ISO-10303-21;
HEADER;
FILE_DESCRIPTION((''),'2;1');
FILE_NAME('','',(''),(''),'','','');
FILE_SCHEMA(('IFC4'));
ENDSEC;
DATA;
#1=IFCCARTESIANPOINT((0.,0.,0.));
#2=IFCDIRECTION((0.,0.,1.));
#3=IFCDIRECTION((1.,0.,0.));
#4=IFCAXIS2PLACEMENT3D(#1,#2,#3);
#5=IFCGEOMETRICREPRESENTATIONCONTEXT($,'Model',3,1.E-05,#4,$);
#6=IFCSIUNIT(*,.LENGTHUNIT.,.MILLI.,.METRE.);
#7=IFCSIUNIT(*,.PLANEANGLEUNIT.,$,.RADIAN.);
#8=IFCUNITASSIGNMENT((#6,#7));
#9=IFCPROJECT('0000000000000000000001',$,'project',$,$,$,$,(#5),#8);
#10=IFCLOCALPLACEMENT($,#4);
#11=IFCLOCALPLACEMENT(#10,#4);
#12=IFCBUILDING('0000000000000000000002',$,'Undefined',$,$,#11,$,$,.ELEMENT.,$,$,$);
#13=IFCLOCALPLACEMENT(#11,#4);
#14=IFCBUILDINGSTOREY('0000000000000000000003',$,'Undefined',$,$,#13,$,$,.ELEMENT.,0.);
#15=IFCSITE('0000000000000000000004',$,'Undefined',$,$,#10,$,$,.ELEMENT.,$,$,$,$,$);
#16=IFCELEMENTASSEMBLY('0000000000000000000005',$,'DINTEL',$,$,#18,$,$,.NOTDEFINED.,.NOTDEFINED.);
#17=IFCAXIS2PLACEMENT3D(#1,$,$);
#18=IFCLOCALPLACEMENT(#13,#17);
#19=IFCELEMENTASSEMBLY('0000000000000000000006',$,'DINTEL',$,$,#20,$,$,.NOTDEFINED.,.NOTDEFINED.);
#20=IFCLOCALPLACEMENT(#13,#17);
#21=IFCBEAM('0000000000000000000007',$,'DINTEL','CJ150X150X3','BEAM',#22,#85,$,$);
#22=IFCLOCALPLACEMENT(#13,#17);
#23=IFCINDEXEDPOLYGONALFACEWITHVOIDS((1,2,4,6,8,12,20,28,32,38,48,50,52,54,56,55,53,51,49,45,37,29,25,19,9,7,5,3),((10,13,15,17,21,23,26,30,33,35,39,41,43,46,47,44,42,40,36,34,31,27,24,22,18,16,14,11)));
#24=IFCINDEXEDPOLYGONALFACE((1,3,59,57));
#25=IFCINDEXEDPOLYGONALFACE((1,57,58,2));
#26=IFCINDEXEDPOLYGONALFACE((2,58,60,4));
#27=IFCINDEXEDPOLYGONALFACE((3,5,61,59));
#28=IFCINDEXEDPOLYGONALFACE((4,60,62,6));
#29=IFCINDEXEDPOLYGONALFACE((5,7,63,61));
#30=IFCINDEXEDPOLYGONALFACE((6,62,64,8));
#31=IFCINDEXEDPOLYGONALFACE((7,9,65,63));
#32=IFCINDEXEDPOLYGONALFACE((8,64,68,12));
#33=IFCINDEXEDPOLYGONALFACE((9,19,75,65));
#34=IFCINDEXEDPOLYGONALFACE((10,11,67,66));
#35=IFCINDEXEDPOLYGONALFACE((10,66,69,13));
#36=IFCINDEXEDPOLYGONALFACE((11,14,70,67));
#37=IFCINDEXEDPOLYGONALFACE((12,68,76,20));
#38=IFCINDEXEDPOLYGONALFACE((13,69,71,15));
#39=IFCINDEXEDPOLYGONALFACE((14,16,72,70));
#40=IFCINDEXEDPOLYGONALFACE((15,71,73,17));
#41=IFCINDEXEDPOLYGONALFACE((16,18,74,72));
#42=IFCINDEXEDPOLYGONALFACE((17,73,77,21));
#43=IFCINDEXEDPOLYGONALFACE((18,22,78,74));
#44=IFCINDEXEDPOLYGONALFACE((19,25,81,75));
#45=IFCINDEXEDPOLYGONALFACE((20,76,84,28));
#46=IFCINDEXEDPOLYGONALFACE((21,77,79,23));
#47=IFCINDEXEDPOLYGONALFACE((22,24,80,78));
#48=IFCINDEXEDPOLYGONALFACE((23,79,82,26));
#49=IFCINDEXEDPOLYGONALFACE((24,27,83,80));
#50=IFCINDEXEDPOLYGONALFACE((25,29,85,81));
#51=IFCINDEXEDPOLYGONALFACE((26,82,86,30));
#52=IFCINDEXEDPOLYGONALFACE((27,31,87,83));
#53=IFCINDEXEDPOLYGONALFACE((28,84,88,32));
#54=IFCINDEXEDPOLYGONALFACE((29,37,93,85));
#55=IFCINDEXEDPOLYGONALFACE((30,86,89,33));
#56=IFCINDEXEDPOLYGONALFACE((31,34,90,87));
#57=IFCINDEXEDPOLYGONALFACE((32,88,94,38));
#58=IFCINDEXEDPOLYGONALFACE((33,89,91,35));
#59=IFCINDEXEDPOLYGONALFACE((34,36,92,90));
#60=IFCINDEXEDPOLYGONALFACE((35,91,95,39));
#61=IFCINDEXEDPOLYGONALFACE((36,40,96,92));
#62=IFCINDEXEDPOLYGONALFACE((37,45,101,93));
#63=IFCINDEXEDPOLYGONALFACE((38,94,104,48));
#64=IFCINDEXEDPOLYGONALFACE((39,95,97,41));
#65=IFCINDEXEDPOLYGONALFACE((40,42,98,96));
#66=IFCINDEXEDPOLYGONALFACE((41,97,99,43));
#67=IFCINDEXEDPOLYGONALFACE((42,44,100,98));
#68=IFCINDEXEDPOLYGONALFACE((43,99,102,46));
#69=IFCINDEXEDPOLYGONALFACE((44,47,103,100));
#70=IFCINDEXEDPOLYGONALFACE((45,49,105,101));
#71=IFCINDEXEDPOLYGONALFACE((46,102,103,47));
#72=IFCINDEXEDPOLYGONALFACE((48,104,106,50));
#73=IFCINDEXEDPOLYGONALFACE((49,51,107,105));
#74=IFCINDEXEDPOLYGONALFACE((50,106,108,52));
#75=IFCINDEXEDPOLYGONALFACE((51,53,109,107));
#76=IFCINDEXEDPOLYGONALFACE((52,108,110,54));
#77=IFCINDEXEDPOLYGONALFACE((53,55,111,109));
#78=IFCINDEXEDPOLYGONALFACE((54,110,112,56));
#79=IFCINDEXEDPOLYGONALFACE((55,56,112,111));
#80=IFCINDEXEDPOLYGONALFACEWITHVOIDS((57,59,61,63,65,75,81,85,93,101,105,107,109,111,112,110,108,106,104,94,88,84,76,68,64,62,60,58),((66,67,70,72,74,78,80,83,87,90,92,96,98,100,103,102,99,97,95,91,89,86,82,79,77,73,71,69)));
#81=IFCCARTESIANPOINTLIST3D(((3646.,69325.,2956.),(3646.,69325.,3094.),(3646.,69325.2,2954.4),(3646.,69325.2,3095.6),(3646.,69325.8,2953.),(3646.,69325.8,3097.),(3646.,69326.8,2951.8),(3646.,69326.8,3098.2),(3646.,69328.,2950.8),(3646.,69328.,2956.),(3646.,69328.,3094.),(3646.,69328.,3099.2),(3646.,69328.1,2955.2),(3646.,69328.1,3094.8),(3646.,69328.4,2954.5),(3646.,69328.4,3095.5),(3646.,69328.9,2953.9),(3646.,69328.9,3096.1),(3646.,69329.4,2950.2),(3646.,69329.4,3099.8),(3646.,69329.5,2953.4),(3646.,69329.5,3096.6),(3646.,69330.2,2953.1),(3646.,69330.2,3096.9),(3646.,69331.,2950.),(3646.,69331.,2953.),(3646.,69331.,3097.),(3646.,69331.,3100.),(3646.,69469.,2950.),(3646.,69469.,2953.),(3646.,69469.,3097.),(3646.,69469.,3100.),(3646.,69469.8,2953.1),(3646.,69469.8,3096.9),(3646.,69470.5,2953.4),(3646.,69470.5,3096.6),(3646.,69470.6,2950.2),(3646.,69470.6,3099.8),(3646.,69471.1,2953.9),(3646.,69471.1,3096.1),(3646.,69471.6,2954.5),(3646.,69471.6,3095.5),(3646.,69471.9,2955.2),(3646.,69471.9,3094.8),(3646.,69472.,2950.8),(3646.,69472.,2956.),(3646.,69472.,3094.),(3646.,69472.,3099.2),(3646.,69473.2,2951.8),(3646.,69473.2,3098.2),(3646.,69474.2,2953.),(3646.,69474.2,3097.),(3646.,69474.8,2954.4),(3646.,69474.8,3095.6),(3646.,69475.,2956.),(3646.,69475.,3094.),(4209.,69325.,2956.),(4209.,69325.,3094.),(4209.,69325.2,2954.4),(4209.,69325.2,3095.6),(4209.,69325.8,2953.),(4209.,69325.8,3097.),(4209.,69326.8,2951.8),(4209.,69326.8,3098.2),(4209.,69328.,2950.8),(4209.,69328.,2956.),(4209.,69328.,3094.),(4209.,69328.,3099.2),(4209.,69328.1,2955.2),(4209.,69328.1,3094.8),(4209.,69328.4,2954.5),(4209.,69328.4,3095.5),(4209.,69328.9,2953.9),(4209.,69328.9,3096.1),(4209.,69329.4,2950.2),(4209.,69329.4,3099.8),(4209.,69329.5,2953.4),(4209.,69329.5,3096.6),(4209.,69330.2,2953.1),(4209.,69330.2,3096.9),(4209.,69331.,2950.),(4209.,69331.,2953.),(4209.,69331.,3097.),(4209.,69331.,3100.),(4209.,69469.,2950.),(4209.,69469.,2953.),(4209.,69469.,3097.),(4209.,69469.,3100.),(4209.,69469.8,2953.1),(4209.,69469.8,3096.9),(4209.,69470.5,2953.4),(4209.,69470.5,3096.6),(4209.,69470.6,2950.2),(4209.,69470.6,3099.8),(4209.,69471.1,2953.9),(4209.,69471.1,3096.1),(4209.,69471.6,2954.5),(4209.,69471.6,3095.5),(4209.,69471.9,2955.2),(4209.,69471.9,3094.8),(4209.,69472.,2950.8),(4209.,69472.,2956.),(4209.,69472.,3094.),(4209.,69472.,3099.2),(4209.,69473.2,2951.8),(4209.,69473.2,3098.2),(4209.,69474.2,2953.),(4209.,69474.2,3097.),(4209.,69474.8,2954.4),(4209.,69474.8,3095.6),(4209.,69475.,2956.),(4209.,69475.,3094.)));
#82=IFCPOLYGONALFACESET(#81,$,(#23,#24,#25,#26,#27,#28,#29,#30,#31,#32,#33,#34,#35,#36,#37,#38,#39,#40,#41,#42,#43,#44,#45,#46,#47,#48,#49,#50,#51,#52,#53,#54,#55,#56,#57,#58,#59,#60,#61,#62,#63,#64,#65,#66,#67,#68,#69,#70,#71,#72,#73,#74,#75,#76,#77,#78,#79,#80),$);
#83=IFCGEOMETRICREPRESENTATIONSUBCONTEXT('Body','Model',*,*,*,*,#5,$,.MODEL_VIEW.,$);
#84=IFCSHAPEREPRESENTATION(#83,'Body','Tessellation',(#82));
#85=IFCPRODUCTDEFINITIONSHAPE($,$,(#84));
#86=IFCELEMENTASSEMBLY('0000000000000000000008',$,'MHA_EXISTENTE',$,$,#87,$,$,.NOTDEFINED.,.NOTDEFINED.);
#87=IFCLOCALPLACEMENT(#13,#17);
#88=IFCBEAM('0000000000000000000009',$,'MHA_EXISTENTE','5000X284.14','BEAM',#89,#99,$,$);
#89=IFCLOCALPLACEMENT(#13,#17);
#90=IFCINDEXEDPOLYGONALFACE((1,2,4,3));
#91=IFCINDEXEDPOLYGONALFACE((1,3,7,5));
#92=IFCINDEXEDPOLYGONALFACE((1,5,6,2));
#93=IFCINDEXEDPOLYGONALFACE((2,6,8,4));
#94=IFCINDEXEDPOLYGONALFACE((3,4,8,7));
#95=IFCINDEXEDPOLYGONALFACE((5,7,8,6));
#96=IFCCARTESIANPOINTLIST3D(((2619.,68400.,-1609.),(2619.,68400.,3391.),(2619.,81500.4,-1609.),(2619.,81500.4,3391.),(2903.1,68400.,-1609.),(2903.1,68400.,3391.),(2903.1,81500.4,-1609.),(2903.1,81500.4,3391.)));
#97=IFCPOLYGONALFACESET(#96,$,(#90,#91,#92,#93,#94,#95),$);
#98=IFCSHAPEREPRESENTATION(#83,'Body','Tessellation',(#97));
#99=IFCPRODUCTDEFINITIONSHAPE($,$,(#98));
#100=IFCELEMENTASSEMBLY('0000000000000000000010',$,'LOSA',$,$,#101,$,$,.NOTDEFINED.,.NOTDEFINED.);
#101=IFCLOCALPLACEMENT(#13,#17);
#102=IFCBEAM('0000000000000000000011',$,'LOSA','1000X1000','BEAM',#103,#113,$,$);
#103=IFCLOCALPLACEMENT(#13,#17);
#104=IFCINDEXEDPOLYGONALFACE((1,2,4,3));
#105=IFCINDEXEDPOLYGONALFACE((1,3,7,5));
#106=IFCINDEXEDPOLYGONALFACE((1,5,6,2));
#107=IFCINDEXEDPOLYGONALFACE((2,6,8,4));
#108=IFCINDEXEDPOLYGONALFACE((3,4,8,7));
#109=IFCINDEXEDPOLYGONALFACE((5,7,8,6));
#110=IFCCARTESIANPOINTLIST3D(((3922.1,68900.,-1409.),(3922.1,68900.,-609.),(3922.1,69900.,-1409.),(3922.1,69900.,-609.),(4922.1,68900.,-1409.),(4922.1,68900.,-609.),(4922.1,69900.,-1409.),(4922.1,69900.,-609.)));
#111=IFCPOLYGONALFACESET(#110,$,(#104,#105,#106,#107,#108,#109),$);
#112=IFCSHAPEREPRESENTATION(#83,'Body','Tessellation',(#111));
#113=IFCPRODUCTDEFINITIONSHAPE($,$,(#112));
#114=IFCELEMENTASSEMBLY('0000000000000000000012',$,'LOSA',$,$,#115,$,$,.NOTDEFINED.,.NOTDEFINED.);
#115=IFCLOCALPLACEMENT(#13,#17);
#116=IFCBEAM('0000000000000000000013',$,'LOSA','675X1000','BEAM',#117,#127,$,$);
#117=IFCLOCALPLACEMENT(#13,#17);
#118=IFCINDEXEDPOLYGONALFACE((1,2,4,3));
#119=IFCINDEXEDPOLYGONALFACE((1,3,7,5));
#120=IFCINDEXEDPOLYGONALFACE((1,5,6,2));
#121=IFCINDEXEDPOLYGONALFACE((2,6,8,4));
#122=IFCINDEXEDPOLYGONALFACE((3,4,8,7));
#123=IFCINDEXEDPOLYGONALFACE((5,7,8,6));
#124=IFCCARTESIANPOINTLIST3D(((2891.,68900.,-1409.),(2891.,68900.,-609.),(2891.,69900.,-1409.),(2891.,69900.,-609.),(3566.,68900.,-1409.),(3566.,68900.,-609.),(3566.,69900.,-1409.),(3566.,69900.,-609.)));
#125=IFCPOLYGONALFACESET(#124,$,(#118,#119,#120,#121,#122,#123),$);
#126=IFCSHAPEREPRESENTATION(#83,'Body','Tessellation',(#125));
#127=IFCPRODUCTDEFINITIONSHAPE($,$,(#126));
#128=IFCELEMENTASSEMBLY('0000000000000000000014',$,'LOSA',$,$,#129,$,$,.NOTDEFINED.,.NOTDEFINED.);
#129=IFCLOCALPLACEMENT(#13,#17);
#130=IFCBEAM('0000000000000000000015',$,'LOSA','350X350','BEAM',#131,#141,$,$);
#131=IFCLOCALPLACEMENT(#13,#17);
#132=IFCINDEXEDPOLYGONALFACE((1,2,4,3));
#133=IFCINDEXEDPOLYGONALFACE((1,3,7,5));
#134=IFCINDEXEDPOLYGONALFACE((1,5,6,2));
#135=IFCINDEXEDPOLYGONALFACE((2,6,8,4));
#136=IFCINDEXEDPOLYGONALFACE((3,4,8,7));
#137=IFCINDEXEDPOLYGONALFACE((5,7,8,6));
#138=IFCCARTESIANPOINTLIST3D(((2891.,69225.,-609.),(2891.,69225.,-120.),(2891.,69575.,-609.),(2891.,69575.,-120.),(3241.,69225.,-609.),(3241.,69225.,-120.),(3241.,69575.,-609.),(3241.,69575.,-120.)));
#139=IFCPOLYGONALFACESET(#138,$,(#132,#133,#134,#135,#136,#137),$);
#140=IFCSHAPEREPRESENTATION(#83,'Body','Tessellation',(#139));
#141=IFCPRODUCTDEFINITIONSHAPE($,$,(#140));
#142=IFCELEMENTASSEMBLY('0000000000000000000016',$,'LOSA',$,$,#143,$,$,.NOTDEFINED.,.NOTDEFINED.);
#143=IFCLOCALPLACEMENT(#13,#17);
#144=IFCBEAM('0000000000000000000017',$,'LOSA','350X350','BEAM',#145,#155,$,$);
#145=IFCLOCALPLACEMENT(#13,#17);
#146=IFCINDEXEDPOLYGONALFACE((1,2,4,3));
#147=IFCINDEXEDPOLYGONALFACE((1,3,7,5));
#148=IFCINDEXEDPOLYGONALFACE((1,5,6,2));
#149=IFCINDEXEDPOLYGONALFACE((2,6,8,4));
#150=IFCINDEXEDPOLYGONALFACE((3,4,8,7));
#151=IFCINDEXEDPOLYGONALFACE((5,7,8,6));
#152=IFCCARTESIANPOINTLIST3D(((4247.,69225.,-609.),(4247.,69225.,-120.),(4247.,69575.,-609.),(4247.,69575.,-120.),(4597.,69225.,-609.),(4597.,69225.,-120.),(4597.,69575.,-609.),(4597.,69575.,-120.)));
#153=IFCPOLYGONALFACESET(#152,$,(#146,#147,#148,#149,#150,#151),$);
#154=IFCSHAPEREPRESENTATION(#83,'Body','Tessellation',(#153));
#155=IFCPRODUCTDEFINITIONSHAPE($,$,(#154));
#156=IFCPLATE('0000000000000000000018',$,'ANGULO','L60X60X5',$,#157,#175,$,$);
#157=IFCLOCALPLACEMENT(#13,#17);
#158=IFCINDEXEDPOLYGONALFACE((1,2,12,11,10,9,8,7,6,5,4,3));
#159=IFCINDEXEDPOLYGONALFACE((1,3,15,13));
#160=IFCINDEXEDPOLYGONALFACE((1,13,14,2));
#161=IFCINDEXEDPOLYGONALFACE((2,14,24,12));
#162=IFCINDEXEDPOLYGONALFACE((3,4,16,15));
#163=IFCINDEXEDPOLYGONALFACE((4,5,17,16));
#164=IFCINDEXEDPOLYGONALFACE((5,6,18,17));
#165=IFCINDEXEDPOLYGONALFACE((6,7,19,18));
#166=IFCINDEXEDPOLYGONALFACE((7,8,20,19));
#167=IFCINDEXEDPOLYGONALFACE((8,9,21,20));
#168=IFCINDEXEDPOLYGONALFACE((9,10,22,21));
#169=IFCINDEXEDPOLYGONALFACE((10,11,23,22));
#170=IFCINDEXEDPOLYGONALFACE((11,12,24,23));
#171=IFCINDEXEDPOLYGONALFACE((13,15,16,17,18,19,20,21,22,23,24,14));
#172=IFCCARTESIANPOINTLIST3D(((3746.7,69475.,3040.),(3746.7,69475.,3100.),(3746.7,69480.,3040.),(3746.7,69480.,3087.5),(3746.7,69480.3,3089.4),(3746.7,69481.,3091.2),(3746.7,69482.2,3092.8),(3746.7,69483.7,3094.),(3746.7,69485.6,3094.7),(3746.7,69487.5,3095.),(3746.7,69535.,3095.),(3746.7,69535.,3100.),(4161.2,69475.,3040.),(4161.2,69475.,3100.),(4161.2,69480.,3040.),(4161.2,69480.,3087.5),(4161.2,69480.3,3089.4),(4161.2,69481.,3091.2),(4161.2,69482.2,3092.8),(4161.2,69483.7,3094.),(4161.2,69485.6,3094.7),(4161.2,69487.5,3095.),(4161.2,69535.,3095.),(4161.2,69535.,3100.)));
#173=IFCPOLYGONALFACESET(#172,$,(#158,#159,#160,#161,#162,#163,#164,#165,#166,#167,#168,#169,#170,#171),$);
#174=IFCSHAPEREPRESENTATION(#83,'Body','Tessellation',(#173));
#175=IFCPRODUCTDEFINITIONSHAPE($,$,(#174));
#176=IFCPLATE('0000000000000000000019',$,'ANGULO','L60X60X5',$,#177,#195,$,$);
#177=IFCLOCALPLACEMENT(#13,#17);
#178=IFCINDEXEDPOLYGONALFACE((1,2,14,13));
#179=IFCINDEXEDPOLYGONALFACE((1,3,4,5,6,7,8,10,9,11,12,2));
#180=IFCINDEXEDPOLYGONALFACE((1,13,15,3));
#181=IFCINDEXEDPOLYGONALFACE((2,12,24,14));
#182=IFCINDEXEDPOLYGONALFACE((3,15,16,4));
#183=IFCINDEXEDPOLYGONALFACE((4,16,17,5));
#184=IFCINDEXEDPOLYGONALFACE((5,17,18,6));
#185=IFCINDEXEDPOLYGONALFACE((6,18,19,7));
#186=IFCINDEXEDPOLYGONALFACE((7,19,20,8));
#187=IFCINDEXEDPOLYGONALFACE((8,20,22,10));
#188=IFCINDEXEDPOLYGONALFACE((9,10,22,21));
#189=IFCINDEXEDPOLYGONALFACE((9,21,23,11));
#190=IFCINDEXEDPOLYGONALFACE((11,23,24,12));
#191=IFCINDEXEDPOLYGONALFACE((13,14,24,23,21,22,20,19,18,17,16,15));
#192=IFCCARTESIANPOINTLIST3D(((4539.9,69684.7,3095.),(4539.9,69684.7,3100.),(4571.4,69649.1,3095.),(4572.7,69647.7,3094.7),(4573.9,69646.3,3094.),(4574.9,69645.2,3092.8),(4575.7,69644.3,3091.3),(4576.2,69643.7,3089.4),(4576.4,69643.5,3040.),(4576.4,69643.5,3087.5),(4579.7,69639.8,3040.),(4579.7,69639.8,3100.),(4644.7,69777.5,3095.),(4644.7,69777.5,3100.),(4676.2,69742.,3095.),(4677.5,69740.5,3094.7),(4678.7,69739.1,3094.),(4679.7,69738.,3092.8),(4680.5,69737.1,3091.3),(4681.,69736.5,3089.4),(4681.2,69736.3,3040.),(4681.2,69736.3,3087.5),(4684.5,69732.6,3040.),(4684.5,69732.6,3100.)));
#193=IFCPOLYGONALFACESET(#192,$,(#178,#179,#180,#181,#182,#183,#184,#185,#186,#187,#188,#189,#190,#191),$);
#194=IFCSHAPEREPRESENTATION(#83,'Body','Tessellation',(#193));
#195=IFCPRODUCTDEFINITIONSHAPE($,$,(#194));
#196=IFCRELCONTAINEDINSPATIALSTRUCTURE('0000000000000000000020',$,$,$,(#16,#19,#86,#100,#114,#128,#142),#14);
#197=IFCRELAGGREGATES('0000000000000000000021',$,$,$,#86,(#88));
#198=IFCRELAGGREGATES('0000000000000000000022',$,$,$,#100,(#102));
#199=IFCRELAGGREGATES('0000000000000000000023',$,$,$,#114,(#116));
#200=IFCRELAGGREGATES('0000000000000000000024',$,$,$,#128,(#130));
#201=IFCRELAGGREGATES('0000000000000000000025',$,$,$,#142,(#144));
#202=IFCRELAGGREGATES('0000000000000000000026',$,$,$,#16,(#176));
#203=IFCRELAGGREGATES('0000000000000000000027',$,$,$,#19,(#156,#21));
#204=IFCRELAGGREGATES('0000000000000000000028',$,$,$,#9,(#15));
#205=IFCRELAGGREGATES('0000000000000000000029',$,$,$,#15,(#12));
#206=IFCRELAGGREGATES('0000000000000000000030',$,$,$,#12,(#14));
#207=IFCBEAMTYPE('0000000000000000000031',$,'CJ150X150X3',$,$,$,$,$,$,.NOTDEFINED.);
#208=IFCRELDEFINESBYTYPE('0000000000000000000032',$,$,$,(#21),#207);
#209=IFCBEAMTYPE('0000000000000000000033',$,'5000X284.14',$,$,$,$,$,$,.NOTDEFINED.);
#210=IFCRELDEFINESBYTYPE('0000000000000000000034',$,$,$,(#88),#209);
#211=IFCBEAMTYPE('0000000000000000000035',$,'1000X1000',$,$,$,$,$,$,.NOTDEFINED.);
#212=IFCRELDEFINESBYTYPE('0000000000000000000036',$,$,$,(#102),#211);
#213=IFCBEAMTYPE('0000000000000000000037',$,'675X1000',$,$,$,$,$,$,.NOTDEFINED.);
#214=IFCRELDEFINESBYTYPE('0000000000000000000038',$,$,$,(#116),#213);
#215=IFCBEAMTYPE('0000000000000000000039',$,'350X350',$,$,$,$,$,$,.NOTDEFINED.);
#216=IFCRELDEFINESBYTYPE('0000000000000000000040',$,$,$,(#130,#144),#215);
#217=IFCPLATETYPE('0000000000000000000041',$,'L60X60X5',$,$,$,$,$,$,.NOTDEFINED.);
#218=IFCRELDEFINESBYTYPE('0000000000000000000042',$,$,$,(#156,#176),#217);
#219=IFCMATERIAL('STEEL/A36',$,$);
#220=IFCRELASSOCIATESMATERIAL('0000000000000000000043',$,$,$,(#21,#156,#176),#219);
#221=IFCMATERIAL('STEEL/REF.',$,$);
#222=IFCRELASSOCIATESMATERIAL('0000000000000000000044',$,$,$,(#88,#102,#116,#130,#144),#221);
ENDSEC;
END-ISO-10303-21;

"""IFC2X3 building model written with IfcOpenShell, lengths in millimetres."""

from ifc_helpers import new_model, si_unit, frame, origin_with_axes, origin_2d_with_axis, place, context, subcontext, project, spatial, rectangle, hollow_rectangle, l_section, extrude, material, type_object, element, aggregate, save


model = new_model("IFC2X3")

# Units and contexts
model_context = context("Model", 3, precision=1e-05, world=origin_with_axes())
body_context = subcontext(model_context, "Body", "Model", "MODEL_VIEW")
ifc_project = project(units=[si_unit("LENGTHUNIT", "METRE", prefix="MILLI"), si_unit("PLANEANGLEUNIT", "RADIAN")], contexts=[model_context])

# Site, building, storey
site_placement = place(None, origin_with_axes())
site = spatial("IfcSite", under=ifc_project, at=site_placement, Name="Undefined", CompositionType="ELEMENT")
building_placement = place(site_placement, origin_with_axes())
building = spatial("IfcBuilding", under=site, at=building_placement, Name="Undefined", CompositionType="ELEMENT")
storey_placement = place(building_placement, origin_with_axes())
storey = spatial("IfcBuildingStorey", under=building, at=storey_placement, Name="Undefined", CompositionType="ELEMENT", Elevation=0.0)

# Element assemblies, beams
assembly_1_placement = place(storey_placement, origin_with_axes())
assembly_1 = element("IfcElementAssembly", 1, at=assembly_1_placement, inside=storey, Name="DINTEL", AssemblyPlace="NOTDEFINED", PredefinedType="NOTDEFINED")
ifc_material_1 = material(Name="STEEL/A36")
beam_type_1 = type_object("IfcBeamType", Name="CJ150X150X3", PredefinedType="NOTDEFINED")
assembly_2_placement = place(storey_placement, origin_with_axes())
assembly_2 = element("IfcElementAssembly", 2, at=assembly_2_placement, inside=storey, Name="DINTEL", AssemblyPlace="NOTDEFINED", PredefinedType="NOTDEFINED")
beam_1_placement = place(assembly_2_placement, frame((3646.0, 69400.0, 3025.0), z_axis=(0.0, 0.0, 1.0), x_axis=(1.0, 0.0, 0.0)))
beam_1 = element("IfcBeam", 3, at=beam_1_placement, type_object=beam_type_1, material=ifc_material_1, Name="DINTEL", Description="CJ150X150X3", ObjectType="BEAM", context=body_context, shape_type="SweptSolid", body=[
    extrude(hollow_rectangle(XDim=150.0, YDim=150.0, WallThickness=3.0, InnerFilletRadius=3.0, OuterFilletRadius=6.0, at=origin_2d_with_axis()), frame((563.0, 0.0, 0.0), z_axis=(-1.0, 0.0, 0.0), x_axis=(0.0, -1.0, 0.0)), (0.0, 0.0, 1.0), 563.0),
])
assembly_3_placement = place(storey_placement, origin_with_axes())
assembly_3 = element("IfcElementAssembly", 4, at=assembly_3_placement, inside=storey, Name="MHA_EXISTENTE", AssemblyPlace="NOTDEFINED", PredefinedType="NOTDEFINED")
ifc_material_2 = material(Name="STEEL/REF.")
beam_type_2 = type_object("IfcBeamType", Name="5000X284.14", PredefinedType="NOTDEFINED")
beam_2_placement = place(assembly_3_placement, frame((2761.1, 68400.0, 891.0), z_axis=(0.0, 0.0, 1.0), x_axis=(0.0, 1.0, 0.0)))
beam_2 = element("IfcBeam", 5, at=beam_2_placement, type_object=beam_type_2, material=ifc_material_2, Name="MHA_EXISTENTE", Description="5000X284.14", ObjectType="BEAM", context=body_context, shape_type="SweptSolid", body=[
    extrude(rectangle(XDim=284.1, YDim=5000.0, at=origin_2d_with_axis()), frame((13100.4, 0.0, 0.0), z_axis=(-1.0, 0.0, 0.0), x_axis=(0.0, -1.0, 0.0)), (0.0, 0.0, 1.0), 13100.4),
])
aggregate(assembly_3, [beam_2])
assembly_4_placement = place(storey_placement, origin_with_axes())
assembly_4 = element("IfcElementAssembly", 6, at=assembly_4_placement, inside=storey, Name="LOSA", AssemblyPlace="NOTDEFINED", PredefinedType="NOTDEFINED")
beam_type_3 = type_object("IfcBeamType", Name="1000X1000", PredefinedType="NOTDEFINED")
beam_3_placement = place(assembly_4_placement, frame((4422.1, 69400.0, -609.0), z_axis=(1.0, 0.0, 0.0), x_axis=(0.0, 0.0, -1.0)))
beam_3 = element("IfcBeam", 7, at=beam_3_placement, type_object=beam_type_3, material=ifc_material_2, Name="LOSA", Description="1000X1000", ObjectType="BEAM", context=body_context, shape_type="SweptSolid", body=[
    extrude(rectangle(XDim=1000.0, YDim=1000.0, at=origin_2d_with_axis()), frame((800.0, 0.0, 0.0), z_axis=(-1.0, 0.0, 0.0), x_axis=(0.0, -1.0, 0.0)), (0.0, 0.0, 1.0), 800.0),
])
aggregate(assembly_4, [beam_3])
assembly_5_placement = place(storey_placement, origin_with_axes())
assembly_5 = element("IfcElementAssembly", 8, at=assembly_5_placement, inside=storey, Name="LOSA", AssemblyPlace="NOTDEFINED", PredefinedType="NOTDEFINED")
beam_type_4 = type_object("IfcBeamType", Name="675X1000", PredefinedType="NOTDEFINED")
beam_4_placement = place(assembly_5_placement, frame((3228.5, 69400.0, -609.0), z_axis=(1.0, 0.0, 0.0), x_axis=(0.0, 0.0, -1.0)))
beam_4 = element("IfcBeam", 9, at=beam_4_placement, type_object=beam_type_4, material=ifc_material_2, Name="LOSA", Description="675X1000", ObjectType="BEAM", context=body_context, shape_type="SweptSolid", body=[
    extrude(rectangle(XDim=1000.0, YDim=675.0, at=origin_2d_with_axis()), frame((800.0, 0.0, 0.0), z_axis=(-1.0, 0.0, 0.0), x_axis=(0.0, -1.0, 0.0)), (0.0, 0.0, 1.0), 800.0),
])
aggregate(assembly_5, [beam_4])
assembly_6_placement = place(storey_placement, origin_with_axes())
assembly_6 = element("IfcElementAssembly", 10, at=assembly_6_placement, inside=storey, Name="LOSA", AssemblyPlace="NOTDEFINED", PredefinedType="NOTDEFINED")
beam_type_5 = type_object("IfcBeamType", Name="350X350", PredefinedType="NOTDEFINED")
beam_5_placement = place(assembly_6_placement, frame((3066.0, 69400.0, -120.0), z_axis=(1.0, 0.0, 0.0), x_axis=(0.0, 0.0, -1.0)))
beam_5 = element("IfcBeam", 11, at=beam_5_placement, type_object=beam_type_5, material=ifc_material_2, Name="LOSA", Description="350X350", ObjectType="BEAM", context=body_context, shape_type="SweptSolid", body=[
    extrude(rectangle(XDim=350.0, YDim=350.0, at=origin_2d_with_axis()), frame((489.0, 0.0, 0.0), z_axis=(-1.0, 0.0, 0.0), x_axis=(0.0, -1.0, 0.0)), (0.0, 0.0, 1.0), 489.0),
])
aggregate(assembly_6, [beam_5])
assembly_7_placement = place(storey_placement, origin_with_axes())
assembly_7 = element("IfcElementAssembly", 12, at=assembly_7_placement, inside=storey, Name="LOSA", AssemblyPlace="NOTDEFINED", PredefinedType="NOTDEFINED")
beam_6_placement = place(assembly_7_placement, frame((4422.0, 69400.0, -120.0), z_axis=(1.0, 0.0, 0.0), x_axis=(0.0, 0.0, -1.0)))
beam_6 = element("IfcBeam", 13, at=beam_6_placement, type_object=beam_type_5, material=ifc_material_2, Name="LOSA", Description="350X350", ObjectType="BEAM", context=body_context, shape_type="SweptSolid", body=[
    extrude(rectangle(XDim=350.0, YDim=350.0, at=origin_2d_with_axis()), frame((489.0, 0.0, 0.0), z_axis=(-1.0, 0.0, 0.0), x_axis=(0.0, -1.0, 0.0)), (0.0, 0.0, 1.0), 489.0),
])
aggregate(assembly_7, [beam_6])

# Plates
plate_type_1 = type_object("IfcPlateType", Name="L60X60X5", PredefinedType="NOTDEFINED")
plate_1_placement = place(assembly_2_placement, frame((3746.7, 69505.0, 3070.0), z_axis=(0.0, 0.0, -1.0), x_axis=(1.0, 0.0, 0.0)))
plate_1 = element("IfcPlate", 14, at=plate_1_placement, type_object=plate_type_1, material=ifc_material_1, Name="ANGULO", Description="L60X60X5", context=body_context, shape_type="SweptSolid", body=[
    extrude(l_section(Depth=60.0, Width=60.0, Thickness=5.0, FilletRadius=7.5, at=origin_2d_with_axis()), frame((414.5, 0.0, 0.0), z_axis=(-1.0, 0.0, 0.0), x_axis=(0.0, -1.0, 0.0)), (0.0, 0.0, 1.0), 414.5),
])
plate_2_placement = place(assembly_1_placement, frame((4559.8, 69662.3, 3070.0), z_axis=(0.0, 0.0, -1.0), x_axis=(0.748701, 0.662908, 0.0)))
plate_2 = element("IfcPlate", 15, at=plate_2_placement, type_object=plate_type_1, material=ifc_material_1, Name="ANGULO", Description="L60X60X5", context=body_context, shape_type="SweptSolid", body=[
    extrude(l_section(Depth=60.0, Width=60.0, Thickness=5.0, FilletRadius=7.5, at=origin_2d_with_axis()), frame((140.0, 0.0, 0.0), z_axis=(-1.0, 0.0, 0.0), x_axis=(0.0, -1.0, 0.0)), (0.0, 0.0, 1.0), 140.0),
])
aggregate(assembly_1, [plate_2])
aggregate(assembly_2, [plate_1, beam_1])

save(model, "model.ifc")
